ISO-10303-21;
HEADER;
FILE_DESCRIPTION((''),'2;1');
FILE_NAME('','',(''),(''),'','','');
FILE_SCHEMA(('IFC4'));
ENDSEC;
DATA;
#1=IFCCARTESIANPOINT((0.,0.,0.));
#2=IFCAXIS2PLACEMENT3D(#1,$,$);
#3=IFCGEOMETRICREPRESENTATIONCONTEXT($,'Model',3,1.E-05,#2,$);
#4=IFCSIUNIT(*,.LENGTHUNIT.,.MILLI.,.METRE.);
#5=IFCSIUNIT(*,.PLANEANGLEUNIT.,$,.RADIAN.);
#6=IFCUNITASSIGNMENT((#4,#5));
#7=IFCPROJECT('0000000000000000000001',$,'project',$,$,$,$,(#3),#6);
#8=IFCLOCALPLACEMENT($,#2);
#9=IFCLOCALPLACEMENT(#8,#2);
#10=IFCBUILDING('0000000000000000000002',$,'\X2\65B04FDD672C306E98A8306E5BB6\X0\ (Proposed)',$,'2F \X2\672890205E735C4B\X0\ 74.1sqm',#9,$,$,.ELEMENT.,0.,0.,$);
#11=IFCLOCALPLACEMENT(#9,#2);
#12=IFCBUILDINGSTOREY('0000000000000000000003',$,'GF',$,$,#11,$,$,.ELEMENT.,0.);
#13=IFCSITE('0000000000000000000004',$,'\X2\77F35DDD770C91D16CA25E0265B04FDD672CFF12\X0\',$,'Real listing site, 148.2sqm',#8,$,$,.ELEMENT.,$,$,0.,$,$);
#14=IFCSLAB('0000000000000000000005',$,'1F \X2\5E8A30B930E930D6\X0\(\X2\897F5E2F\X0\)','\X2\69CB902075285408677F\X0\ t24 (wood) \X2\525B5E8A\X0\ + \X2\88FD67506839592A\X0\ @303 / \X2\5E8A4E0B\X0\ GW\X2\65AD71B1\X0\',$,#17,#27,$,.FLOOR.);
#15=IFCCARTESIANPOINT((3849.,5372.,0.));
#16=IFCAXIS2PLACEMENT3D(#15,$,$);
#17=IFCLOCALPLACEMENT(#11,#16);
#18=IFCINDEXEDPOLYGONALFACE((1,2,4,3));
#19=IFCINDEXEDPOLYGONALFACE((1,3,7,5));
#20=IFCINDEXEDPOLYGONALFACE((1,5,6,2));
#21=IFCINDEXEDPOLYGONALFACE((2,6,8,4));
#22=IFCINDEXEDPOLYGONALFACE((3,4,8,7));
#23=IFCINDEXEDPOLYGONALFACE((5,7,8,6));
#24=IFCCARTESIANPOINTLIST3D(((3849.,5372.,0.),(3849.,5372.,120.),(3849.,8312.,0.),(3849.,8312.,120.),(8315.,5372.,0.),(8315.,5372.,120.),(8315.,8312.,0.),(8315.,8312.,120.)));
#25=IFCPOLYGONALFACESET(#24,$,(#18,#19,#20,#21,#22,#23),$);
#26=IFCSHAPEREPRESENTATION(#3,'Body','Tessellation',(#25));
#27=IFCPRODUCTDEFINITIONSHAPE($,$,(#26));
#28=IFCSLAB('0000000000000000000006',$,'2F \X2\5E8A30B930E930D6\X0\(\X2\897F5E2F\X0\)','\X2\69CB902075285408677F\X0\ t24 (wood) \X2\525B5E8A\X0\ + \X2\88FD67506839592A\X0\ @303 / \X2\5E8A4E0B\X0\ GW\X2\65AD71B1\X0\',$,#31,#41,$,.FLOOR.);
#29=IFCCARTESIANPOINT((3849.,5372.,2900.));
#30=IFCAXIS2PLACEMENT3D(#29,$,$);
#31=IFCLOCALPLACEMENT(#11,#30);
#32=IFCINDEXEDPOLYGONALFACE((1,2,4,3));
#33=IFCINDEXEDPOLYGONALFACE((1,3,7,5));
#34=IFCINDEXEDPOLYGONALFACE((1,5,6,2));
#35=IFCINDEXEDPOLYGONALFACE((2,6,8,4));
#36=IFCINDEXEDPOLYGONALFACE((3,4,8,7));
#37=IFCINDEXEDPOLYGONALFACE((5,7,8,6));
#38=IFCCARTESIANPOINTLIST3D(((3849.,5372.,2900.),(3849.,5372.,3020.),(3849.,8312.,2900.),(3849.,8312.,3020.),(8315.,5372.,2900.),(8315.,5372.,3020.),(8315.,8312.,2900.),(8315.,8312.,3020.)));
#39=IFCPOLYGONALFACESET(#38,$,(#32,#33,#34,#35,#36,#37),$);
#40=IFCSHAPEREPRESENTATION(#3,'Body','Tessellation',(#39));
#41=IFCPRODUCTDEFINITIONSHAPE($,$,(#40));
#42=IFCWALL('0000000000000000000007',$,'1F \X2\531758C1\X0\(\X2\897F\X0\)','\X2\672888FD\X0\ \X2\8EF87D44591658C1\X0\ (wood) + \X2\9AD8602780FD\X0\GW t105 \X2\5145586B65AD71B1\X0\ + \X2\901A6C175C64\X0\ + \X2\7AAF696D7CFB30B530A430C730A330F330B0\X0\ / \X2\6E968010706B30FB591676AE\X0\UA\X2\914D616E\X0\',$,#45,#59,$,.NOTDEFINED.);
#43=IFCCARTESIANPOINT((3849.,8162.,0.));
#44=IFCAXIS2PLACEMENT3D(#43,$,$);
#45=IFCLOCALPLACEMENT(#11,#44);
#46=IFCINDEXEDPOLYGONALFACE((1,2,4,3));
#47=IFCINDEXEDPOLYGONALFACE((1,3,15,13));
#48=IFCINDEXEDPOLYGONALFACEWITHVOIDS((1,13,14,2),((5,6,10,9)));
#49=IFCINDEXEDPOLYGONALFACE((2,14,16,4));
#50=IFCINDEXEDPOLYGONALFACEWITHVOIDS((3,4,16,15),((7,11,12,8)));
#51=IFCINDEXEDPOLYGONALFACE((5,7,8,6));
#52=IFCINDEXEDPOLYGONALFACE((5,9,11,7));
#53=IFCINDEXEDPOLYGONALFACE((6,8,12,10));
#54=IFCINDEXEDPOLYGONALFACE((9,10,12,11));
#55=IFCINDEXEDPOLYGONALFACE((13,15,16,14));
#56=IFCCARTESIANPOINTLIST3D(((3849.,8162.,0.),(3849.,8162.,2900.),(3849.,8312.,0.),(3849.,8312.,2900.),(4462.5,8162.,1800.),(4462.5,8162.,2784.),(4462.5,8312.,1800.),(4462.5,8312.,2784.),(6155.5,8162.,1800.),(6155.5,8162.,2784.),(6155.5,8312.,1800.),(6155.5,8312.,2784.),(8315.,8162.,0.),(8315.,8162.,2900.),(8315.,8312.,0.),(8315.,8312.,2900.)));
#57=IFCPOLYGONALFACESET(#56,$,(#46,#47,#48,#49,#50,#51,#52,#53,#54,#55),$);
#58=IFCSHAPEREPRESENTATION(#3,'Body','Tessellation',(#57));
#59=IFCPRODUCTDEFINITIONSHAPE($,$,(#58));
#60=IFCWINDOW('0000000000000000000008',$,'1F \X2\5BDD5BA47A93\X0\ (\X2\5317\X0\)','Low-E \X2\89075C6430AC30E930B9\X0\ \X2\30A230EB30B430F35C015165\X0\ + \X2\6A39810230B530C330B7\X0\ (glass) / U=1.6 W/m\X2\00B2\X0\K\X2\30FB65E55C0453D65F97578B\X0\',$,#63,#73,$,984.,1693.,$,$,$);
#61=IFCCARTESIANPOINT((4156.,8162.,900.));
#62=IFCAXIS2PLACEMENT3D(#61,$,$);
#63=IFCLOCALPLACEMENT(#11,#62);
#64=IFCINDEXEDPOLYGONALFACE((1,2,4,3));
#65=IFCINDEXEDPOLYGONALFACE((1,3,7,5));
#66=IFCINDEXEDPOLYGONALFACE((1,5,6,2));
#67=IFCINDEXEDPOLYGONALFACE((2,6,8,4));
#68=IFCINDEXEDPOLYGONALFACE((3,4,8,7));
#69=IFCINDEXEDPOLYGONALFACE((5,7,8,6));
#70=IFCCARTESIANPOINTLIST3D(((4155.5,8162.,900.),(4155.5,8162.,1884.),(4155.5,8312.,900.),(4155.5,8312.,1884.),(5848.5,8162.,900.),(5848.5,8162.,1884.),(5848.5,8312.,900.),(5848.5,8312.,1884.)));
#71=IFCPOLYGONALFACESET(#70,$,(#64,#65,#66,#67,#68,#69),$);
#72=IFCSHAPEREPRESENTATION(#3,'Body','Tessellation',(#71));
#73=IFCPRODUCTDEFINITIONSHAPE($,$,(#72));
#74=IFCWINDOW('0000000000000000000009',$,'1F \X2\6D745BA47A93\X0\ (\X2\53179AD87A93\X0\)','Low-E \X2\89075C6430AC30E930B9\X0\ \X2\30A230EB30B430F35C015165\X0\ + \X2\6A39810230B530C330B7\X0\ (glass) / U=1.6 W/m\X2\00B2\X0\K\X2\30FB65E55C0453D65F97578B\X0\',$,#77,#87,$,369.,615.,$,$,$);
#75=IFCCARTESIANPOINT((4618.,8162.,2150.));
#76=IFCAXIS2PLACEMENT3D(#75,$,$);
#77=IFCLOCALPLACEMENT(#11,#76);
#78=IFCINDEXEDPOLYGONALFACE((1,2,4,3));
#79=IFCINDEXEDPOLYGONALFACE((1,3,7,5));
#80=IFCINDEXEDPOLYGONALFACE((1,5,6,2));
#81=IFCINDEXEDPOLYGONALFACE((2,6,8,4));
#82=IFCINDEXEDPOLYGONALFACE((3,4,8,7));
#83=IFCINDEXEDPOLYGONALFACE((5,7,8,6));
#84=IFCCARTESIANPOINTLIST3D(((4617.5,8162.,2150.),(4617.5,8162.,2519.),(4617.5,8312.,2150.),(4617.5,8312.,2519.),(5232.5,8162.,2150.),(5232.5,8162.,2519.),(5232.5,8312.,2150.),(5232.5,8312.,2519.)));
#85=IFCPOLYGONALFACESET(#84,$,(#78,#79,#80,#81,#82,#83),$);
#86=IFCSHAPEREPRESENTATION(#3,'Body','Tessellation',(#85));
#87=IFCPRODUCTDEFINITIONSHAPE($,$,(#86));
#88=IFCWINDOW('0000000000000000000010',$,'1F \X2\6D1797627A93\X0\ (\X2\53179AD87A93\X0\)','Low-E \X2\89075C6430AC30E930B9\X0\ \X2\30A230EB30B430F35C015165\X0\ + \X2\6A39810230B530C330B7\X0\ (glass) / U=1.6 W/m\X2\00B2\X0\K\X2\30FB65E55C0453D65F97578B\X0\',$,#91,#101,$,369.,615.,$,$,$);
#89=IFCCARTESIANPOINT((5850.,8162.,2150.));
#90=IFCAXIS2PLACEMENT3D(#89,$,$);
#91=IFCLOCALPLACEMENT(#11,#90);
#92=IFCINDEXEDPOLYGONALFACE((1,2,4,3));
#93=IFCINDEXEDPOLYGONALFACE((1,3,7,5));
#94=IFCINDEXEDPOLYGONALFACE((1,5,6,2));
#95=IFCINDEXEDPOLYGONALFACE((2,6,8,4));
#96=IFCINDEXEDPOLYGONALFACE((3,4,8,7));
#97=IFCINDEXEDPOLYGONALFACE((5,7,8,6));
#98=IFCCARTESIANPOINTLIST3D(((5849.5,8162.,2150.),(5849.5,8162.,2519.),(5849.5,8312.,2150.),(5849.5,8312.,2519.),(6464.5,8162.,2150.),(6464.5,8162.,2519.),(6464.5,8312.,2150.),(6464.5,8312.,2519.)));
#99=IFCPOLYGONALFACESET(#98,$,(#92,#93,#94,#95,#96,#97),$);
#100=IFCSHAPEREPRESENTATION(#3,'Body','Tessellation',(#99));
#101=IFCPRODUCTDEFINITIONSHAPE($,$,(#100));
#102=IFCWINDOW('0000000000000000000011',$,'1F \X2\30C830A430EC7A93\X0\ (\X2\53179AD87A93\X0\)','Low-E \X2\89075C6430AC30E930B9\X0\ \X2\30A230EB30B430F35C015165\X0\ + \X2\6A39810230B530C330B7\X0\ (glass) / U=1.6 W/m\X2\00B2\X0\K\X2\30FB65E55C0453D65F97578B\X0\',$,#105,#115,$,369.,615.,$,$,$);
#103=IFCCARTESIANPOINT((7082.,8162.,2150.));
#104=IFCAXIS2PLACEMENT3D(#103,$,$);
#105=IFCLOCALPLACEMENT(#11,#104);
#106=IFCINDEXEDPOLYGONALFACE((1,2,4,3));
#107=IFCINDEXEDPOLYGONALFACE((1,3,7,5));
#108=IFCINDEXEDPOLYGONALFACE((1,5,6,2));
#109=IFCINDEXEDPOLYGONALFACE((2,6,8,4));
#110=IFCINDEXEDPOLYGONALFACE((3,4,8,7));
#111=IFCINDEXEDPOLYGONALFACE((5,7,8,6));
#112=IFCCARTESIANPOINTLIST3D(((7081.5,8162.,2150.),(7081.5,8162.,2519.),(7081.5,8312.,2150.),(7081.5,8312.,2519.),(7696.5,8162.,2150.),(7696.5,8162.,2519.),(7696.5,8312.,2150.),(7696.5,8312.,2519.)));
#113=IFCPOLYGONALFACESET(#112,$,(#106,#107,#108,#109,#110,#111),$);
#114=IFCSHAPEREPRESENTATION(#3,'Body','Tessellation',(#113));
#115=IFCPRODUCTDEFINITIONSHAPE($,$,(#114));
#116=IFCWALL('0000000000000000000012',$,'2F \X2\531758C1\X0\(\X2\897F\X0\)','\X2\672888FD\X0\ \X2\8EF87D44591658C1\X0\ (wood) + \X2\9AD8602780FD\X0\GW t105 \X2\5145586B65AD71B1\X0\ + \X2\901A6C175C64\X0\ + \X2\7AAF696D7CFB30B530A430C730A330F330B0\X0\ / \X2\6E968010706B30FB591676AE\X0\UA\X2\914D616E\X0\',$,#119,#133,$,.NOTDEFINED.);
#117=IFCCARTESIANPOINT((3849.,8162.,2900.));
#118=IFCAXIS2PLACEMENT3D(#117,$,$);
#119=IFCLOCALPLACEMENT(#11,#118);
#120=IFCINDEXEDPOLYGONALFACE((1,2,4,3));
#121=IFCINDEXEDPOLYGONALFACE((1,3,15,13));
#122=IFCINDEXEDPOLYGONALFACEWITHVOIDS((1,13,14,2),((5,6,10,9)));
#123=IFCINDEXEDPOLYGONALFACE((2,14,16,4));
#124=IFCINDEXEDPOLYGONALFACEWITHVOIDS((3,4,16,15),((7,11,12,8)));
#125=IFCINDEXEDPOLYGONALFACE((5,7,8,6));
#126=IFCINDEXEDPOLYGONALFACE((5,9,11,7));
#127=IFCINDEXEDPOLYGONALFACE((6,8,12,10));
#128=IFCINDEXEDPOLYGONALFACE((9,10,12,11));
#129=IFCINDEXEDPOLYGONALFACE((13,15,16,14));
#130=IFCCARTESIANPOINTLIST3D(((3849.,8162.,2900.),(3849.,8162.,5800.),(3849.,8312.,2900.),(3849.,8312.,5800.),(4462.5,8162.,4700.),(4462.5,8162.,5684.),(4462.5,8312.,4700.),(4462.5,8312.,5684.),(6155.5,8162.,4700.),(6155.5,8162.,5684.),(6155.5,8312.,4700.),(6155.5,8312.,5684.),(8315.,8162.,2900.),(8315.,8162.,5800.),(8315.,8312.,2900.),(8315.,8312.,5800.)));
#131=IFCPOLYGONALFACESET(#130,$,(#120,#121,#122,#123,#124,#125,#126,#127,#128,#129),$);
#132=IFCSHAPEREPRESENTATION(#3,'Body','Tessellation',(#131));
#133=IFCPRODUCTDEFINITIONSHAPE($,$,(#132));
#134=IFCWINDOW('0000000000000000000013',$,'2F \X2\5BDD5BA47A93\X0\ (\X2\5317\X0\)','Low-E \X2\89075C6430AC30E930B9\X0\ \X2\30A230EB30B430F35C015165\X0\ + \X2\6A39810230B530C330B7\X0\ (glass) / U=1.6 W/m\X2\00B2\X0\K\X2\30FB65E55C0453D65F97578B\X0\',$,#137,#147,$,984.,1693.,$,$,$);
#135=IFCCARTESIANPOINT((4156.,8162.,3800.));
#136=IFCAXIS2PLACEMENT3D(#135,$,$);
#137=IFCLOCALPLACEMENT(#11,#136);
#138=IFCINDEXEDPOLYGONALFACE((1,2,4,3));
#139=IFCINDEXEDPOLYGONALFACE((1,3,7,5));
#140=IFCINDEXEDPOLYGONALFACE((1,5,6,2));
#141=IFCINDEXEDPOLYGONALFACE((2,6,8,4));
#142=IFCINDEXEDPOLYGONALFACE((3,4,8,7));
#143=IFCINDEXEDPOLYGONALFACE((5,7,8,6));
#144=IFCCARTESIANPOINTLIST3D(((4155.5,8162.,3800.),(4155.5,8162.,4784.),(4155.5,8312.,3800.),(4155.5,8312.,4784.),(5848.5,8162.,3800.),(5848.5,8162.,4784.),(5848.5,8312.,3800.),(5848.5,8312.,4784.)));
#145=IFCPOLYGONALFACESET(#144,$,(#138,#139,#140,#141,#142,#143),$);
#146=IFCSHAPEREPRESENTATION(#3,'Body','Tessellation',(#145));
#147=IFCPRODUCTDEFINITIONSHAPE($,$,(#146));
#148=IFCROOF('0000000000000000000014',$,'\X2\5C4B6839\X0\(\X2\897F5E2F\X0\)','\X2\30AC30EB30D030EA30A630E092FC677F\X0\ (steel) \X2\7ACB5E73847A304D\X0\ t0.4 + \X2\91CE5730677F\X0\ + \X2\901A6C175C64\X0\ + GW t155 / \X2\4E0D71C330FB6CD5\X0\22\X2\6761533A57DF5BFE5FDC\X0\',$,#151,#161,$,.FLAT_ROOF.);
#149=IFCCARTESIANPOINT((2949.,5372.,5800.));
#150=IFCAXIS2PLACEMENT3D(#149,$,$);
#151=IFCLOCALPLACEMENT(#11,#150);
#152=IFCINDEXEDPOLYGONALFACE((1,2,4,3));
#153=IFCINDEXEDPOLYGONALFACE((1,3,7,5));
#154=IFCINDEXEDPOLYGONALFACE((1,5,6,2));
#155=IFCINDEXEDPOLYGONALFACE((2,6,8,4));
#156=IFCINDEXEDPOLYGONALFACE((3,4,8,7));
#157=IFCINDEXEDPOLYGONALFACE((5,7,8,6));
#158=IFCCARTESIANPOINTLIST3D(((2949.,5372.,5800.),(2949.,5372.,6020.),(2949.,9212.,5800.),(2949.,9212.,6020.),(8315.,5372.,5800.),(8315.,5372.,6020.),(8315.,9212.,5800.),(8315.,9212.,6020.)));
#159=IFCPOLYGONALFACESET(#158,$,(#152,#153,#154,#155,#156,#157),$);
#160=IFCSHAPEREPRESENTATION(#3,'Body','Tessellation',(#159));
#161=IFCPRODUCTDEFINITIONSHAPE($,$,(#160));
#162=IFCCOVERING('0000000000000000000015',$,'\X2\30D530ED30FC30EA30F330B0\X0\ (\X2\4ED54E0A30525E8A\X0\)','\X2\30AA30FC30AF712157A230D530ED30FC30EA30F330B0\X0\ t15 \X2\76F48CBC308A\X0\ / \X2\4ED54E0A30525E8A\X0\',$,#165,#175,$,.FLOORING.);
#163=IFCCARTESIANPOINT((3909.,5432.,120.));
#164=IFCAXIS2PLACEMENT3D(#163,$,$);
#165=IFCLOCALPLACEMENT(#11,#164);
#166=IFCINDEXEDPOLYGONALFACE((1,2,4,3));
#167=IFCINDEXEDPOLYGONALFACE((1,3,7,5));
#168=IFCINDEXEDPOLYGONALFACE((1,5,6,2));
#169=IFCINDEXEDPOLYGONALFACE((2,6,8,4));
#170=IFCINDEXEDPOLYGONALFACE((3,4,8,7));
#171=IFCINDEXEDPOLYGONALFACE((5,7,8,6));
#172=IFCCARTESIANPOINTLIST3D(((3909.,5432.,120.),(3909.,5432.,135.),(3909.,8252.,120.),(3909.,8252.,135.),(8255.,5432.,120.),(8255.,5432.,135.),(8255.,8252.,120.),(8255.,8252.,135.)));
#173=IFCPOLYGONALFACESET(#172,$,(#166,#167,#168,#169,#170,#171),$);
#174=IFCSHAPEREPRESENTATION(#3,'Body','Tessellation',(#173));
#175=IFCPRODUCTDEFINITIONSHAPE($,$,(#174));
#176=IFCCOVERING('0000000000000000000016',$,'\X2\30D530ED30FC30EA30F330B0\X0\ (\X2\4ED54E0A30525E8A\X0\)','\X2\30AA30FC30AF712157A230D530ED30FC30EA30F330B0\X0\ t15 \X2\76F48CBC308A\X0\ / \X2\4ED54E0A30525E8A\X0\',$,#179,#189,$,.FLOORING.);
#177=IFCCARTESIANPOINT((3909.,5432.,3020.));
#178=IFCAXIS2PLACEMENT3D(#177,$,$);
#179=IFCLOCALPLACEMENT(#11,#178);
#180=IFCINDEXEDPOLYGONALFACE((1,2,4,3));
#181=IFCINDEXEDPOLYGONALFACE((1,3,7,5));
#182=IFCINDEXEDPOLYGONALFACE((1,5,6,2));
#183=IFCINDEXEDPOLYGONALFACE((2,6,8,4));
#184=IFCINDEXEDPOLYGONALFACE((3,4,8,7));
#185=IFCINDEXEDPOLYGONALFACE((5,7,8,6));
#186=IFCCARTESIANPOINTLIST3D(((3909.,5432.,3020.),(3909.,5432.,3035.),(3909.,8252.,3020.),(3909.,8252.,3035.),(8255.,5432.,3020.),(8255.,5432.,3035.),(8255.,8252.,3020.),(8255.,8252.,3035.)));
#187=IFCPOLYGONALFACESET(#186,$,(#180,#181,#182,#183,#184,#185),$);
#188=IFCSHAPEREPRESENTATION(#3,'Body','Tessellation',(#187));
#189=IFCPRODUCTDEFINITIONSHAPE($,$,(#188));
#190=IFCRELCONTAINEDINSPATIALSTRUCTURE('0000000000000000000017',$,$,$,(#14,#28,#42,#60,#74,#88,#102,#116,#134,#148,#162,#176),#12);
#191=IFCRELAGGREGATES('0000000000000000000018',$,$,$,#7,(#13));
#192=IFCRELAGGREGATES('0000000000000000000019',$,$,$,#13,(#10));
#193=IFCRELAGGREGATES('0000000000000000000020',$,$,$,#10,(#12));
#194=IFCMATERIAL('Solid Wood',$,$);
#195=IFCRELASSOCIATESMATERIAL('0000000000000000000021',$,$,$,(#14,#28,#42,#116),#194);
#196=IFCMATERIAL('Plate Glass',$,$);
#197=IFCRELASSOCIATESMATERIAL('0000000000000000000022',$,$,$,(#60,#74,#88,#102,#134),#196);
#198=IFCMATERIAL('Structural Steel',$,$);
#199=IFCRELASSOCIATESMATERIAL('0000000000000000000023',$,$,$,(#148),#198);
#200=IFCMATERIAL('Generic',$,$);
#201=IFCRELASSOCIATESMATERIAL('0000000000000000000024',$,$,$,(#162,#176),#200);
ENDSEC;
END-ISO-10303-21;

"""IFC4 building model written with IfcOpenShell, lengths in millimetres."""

from ifc_helpers import new_model, si_unit, frame, frame_2d, origin, place, context, project, spatial, rectangle, extrude, material, element, fill, save


model = new_model("IFC4")

# Units and contexts
model_context = context("Model", 3, precision=1e-05, world=origin())
ifc_project = project(units=[si_unit("LENGTHUNIT", "METRE", prefix="MILLI"), si_unit("PLANEANGLEUNIT", "RADIAN")], contexts=[model_context])

# Site, building, storey
site_placement = place(None, origin())
site = spatial("IfcSite", under=ifc_project, at=site_placement, Name="石川県金沢市新保本２", ObjectType="Real listing site, 148.2sqm", CompositionType="ELEMENT", RefElevation=0.0)
building_placement = place(site_placement, origin())
building = spatial("IfcBuilding", under=site, at=building_placement, Name="新保本の風の家 (Proposed)", ObjectType="2F 木造平屋 74.1sqm", CompositionType="ELEMENT", ElevationOfRefHeight=0.0, ElevationOfTerrain=0.0)
storey_placement = place(building_placement, origin())
storey = spatial("IfcBuildingStorey", under=building, at=storey_placement, Name="GF", CompositionType="ELEMENT", Elevation=0.0)

# Slabs
ifc_material_1 = material(Name="Solid Wood")
slab_1_placement = place(storey_placement, frame((3849.0, 5372.0, 0.0)))
element("IfcSlab", 1, at=slab_1_placement, inside=storey, material=ifc_material_1, Name="1F 床スラブ(西帯)", Description="構造用合板 t24 (wood) 剛床 + 製材根太 @303 / 床下 GW断熱", PredefinedType="FLOOR", context=model_context, shape_type="SweptSolid", body=[
    extrude(rectangle(XDim=4466.0, YDim=2940.0, at=frame_2d((2233.0, 1470.0))), frame((3849.0, 5372.0, 0.0)), (0.0, 0.0, 1.0), 120.0),
])
slab_2_placement = place(storey_placement, frame((3849.0, 5372.0, 2900.0)))
element("IfcSlab", 2, at=slab_2_placement, inside=storey, material=ifc_material_1, Name="2F 床スラブ(西帯)", Description="構造用合板 t24 (wood) 剛床 + 製材根太 @303 / 床下 GW断熱", PredefinedType="FLOOR", context=model_context, shape_type="SweptSolid", body=[
    extrude(rectangle(XDim=4466.0, YDim=2940.0, at=frame_2d((2233.0, 1470.0))), frame((3849.0, 5372.0, 2900.0)), (0.0, 0.0, 1.0), 120.0),
])

# Wall, openings, windows
wall_1_placement = place(storey_placement, frame((3849.0, 8162.0, 0.0)))
wall_1 = element("IfcWall", 3, at=wall_1_placement, inside=storey, material=ifc_material_1, Name="1F 北壁(西)", Description="木製 軸組外壁 (wood) + 高性能GW t105 充填断熱 + 通気層 + 窯業系サイディング / 準耐火・外皮UA配慮", PredefinedType="NOTDEFINED", context=model_context, shape_type="SweptSolid", body=[
    extrude(rectangle(XDim=4466.0, YDim=150.0, at=frame_2d((2233.0, 75.0))), frame((3849.0, 8162.0, 0.0)), (0.0, 0.0, 1.0), 2900.0),
])
opening_1_placement = place(storey_placement, frame((4156.0, 8162.0, 900.0)))
opening_1 = element("IfcOpeningElement", 4, at=opening_1_placement, cuts=wall_1, PredefinedType="NOTDEFINED", context=model_context, shape_type="SweptSolid", body=[
    extrude(rectangle(XDim=1693.0, YDim=150.0, at=frame_2d((846.0, 75.0))), frame((4156.0, 8162.0, 900.0)), (0.0, 0.0, 1.0), 984.0),
])
opening_2_placement = place(storey_placement, frame((4618.0, 8162.0, 2150.0)))
opening_2 = element("IfcOpeningElement", 5, at=opening_2_placement, cuts=wall_1, PredefinedType="NOTDEFINED", context=model_context, shape_type="SweptSolid", body=[
    extrude(rectangle(XDim=615.0, YDim=150.0, at=frame_2d((307.0, 75.0))), frame((4618.0, 8162.0, 2150.0)), (0.0, 0.0, 1.0), 369.0),
])
opening_3_placement = place(storey_placement, frame((5850.0, 8162.0, 2150.0)))
opening_3 = element("IfcOpeningElement", 6, at=opening_3_placement, cuts=wall_1, PredefinedType="NOTDEFINED", context=model_context, shape_type="SweptSolid", body=[
    extrude(rectangle(XDim=615.0, YDim=150.0, at=frame_2d((307.0, 75.0))), frame((5850.0, 8162.0, 2150.0)), (0.0, 0.0, 1.0), 369.0),
])
opening_4_placement = place(storey_placement, frame((7082.0, 8162.0, 2150.0)))
opening_4 = element("IfcOpeningElement", 7, at=opening_4_placement, cuts=wall_1, PredefinedType="NOTDEFINED", context=model_context, shape_type="SweptSolid", body=[
    extrude(rectangle(XDim=615.0, YDim=150.0, at=frame_2d((307.0, 75.0))), frame((7082.0, 8162.0, 2150.0)), (0.0, 0.0, 1.0), 369.0),
])
ifc_material_2 = material(Name="Plate Glass")
window_1_placement = place(storey_placement, frame((4156.0, 8162.0, 900.0)))
window_1 = element("IfcWindow", 8, at=window_1_placement, inside=storey, material=ifc_material_2, Name="1F 寝室窓 (北)", Description="Low-E 複層ガラス アルゴン封入 + 樹脂サッシ (glass) / U=1.6 W/m²K・日射取得型", OverallHeight=984.0, OverallWidth=1693.0, context=model_context, shape_type="SweptSolid", body=[
    extrude(rectangle(XDim=1693.0, YDim=150.0, at=frame_2d((846.0, 75.0))), frame((4156.0, 8162.0, 900.0)), (0.0, 0.0, 1.0), 984.0),
])
fill(opening_1, window_1)
window_2_placement = place(storey_placement, frame((4618.0, 8162.0, 2150.0)))
window_2 = element("IfcWindow", 9, at=window_2_placement, inside=storey, material=ifc_material_2, Name="1F 浴室窓 (北高窓)", Description="Low-E 複層ガラス アルゴン封入 + 樹脂サッシ (glass) / U=1.6 W/m²K・日射取得型", OverallHeight=369.0, OverallWidth=615.0, context=model_context, shape_type="SweptSolid", body=[
    extrude(rectangle(XDim=615.0, YDim=150.0, at=frame_2d((307.0, 75.0))), frame((4618.0, 8162.0, 2150.0)), (0.0, 0.0, 1.0), 369.0),
])
fill(opening_2, window_2)
window_3_placement = place(storey_placement, frame((5850.0, 8162.0, 2150.0)))
window_3 = element("IfcWindow", 10, at=window_3_placement, inside=storey, material=ifc_material_2, Name="1F 洗面窓 (北高窓)", Description="Low-E 複層ガラス アルゴン封入 + 樹脂サッシ (glass) / U=1.6 W/m²K・日射取得型", OverallHeight=369.0, OverallWidth=615.0, context=model_context, shape_type="SweptSolid", body=[
    extrude(rectangle(XDim=615.0, YDim=150.0, at=frame_2d((307.0, 75.0))), frame((5850.0, 8162.0, 2150.0)), (0.0, 0.0, 1.0), 369.0),
])
fill(opening_3, window_3)
window_4_placement = place(storey_placement, frame((7082.0, 8162.0, 2150.0)))
window_4 = element("IfcWindow", 11, at=window_4_placement, inside=storey, material=ifc_material_2, Name="1F トイレ窓 (北高窓)", Description="Low-E 複層ガラス アルゴン封入 + 樹脂サッシ (glass) / U=1.6 W/m²K・日射取得型", OverallHeight=369.0, OverallWidth=615.0, context=model_context, shape_type="SweptSolid", body=[
    extrude(rectangle(XDim=615.0, YDim=150.0, at=frame_2d((307.0, 75.0))), frame((7082.0, 8162.0, 2150.0)), (0.0, 0.0, 1.0), 369.0),
])
fill(opening_4, window_4)

# Wall, opening, window
wall_2_placement = place(storey_placement, frame((3849.0, 8162.0, 2900.0)))
wall_2 = element("IfcWall", 12, at=wall_2_placement, inside=storey, material=ifc_material_1, Name="2F 北壁(西)", Description="木製 軸組外壁 (wood) + 高性能GW t105 充填断熱 + 通気層 + 窯業系サイディング / 準耐火・外皮UA配慮", PredefinedType="NOTDEFINED", context=model_context, shape_type="SweptSolid", body=[
    extrude(rectangle(XDim=4466.0, YDim=150.0, at=frame_2d((2233.0, 75.0))), frame((3849.0, 8162.0, 2900.0)), (0.0, 0.0, 1.0), 2900.0),
])
opening_5_placement = place(storey_placement, frame((4156.0, 8162.0, 3800.0)))
opening_5 = element("IfcOpeningElement", 13, at=opening_5_placement, cuts=wall_2, PredefinedType="NOTDEFINED", context=model_context, shape_type="SweptSolid", body=[
    extrude(rectangle(XDim=1693.0, YDim=150.0, at=frame_2d((846.0, 75.0))), frame((4156.0, 8162.0, 3800.0)), (0.0, 0.0, 1.0), 984.0),
])
window_5_placement = place(storey_placement, frame((4156.0, 8162.0, 3800.0)))
window_5 = element("IfcWindow", 14, at=window_5_placement, inside=storey, material=ifc_material_2, Name="2F 寝室窓 (北)", Description="Low-E 複層ガラス アルゴン封入 + 樹脂サッシ (glass) / U=1.6 W/m²K・日射取得型", OverallHeight=984.0, OverallWidth=1693.0, context=model_context, shape_type="SweptSolid", body=[
    extrude(rectangle(XDim=1693.0, YDim=150.0, at=frame_2d((846.0, 75.0))), frame((4156.0, 8162.0, 3800.0)), (0.0, 0.0, 1.0), 984.0),
])
fill(opening_5, window_5)

# Roof
ifc_material_3 = material(Name="Structural Steel")
for number, where, name in (
    (15, (2949.0, 5372.0, 5800.0), "屋根(西帯)"),
):
    element("IfcRoof", number, at=place(storey_placement, frame(where)), inside=storey, material=ifc_material_3, Name=name, Description="ガルバリウム鋼板 (steel) 立平葺き t0.4 + 野地板 + 通気層 + GW t155 / 不燃・法22条区域対応", PredefinedType="FLAT_ROOF", context=model_context, shape_type="SweptSolid", body=[
        extrude(rectangle(XDim=5366.0, YDim=3840.0, at=frame_2d((2683.0, 1920.0))), frame((2949.0, 5372.0, 5800.0)), (0.0, 0.0, 1.0), 220.0),
    ])

# Coverings
ifc_material_4 = material(Name="Generic")
covering_1_placement = place(storey_placement, frame((3909.0, 5432.0, 120.0)))
element("IfcCovering", 16, at=covering_1_placement, inside=storey, material=ifc_material_4, Name="フローリング (仕上げ床)", Description="オーク無垢フローリング t15 直貼り / 仕上げ床", PredefinedType="FLOORING", context=model_context, shape_type="SweptSolid", body=[
    extrude(rectangle(XDim=4346.0, YDim=2820.0, at=frame_2d((2173.0, 1410.0))), frame((3909.0, 5432.0, 120.0)), (0.0, 0.0, 1.0), 15.0),
])
covering_2_placement = place(storey_placement, frame((3909.0, 5432.0, 3020.0)))
element("IfcCovering", 17, at=covering_2_placement, inside=storey, material=ifc_material_4, Name="フローリング (仕上げ床)", Description="オーク無垢フローリング t15 直貼り / 仕上げ床", PredefinedType="FLOORING", context=model_context, shape_type="SweptSolid", body=[
    extrude(rectangle(XDim=4346.0, YDim=2820.0, at=frame_2d((2173.0, 1410.0))), frame((3909.0, 5432.0, 3020.0)), (0.0, 0.0, 1.0), 15.0),
])

save(model, "model.ifc")
